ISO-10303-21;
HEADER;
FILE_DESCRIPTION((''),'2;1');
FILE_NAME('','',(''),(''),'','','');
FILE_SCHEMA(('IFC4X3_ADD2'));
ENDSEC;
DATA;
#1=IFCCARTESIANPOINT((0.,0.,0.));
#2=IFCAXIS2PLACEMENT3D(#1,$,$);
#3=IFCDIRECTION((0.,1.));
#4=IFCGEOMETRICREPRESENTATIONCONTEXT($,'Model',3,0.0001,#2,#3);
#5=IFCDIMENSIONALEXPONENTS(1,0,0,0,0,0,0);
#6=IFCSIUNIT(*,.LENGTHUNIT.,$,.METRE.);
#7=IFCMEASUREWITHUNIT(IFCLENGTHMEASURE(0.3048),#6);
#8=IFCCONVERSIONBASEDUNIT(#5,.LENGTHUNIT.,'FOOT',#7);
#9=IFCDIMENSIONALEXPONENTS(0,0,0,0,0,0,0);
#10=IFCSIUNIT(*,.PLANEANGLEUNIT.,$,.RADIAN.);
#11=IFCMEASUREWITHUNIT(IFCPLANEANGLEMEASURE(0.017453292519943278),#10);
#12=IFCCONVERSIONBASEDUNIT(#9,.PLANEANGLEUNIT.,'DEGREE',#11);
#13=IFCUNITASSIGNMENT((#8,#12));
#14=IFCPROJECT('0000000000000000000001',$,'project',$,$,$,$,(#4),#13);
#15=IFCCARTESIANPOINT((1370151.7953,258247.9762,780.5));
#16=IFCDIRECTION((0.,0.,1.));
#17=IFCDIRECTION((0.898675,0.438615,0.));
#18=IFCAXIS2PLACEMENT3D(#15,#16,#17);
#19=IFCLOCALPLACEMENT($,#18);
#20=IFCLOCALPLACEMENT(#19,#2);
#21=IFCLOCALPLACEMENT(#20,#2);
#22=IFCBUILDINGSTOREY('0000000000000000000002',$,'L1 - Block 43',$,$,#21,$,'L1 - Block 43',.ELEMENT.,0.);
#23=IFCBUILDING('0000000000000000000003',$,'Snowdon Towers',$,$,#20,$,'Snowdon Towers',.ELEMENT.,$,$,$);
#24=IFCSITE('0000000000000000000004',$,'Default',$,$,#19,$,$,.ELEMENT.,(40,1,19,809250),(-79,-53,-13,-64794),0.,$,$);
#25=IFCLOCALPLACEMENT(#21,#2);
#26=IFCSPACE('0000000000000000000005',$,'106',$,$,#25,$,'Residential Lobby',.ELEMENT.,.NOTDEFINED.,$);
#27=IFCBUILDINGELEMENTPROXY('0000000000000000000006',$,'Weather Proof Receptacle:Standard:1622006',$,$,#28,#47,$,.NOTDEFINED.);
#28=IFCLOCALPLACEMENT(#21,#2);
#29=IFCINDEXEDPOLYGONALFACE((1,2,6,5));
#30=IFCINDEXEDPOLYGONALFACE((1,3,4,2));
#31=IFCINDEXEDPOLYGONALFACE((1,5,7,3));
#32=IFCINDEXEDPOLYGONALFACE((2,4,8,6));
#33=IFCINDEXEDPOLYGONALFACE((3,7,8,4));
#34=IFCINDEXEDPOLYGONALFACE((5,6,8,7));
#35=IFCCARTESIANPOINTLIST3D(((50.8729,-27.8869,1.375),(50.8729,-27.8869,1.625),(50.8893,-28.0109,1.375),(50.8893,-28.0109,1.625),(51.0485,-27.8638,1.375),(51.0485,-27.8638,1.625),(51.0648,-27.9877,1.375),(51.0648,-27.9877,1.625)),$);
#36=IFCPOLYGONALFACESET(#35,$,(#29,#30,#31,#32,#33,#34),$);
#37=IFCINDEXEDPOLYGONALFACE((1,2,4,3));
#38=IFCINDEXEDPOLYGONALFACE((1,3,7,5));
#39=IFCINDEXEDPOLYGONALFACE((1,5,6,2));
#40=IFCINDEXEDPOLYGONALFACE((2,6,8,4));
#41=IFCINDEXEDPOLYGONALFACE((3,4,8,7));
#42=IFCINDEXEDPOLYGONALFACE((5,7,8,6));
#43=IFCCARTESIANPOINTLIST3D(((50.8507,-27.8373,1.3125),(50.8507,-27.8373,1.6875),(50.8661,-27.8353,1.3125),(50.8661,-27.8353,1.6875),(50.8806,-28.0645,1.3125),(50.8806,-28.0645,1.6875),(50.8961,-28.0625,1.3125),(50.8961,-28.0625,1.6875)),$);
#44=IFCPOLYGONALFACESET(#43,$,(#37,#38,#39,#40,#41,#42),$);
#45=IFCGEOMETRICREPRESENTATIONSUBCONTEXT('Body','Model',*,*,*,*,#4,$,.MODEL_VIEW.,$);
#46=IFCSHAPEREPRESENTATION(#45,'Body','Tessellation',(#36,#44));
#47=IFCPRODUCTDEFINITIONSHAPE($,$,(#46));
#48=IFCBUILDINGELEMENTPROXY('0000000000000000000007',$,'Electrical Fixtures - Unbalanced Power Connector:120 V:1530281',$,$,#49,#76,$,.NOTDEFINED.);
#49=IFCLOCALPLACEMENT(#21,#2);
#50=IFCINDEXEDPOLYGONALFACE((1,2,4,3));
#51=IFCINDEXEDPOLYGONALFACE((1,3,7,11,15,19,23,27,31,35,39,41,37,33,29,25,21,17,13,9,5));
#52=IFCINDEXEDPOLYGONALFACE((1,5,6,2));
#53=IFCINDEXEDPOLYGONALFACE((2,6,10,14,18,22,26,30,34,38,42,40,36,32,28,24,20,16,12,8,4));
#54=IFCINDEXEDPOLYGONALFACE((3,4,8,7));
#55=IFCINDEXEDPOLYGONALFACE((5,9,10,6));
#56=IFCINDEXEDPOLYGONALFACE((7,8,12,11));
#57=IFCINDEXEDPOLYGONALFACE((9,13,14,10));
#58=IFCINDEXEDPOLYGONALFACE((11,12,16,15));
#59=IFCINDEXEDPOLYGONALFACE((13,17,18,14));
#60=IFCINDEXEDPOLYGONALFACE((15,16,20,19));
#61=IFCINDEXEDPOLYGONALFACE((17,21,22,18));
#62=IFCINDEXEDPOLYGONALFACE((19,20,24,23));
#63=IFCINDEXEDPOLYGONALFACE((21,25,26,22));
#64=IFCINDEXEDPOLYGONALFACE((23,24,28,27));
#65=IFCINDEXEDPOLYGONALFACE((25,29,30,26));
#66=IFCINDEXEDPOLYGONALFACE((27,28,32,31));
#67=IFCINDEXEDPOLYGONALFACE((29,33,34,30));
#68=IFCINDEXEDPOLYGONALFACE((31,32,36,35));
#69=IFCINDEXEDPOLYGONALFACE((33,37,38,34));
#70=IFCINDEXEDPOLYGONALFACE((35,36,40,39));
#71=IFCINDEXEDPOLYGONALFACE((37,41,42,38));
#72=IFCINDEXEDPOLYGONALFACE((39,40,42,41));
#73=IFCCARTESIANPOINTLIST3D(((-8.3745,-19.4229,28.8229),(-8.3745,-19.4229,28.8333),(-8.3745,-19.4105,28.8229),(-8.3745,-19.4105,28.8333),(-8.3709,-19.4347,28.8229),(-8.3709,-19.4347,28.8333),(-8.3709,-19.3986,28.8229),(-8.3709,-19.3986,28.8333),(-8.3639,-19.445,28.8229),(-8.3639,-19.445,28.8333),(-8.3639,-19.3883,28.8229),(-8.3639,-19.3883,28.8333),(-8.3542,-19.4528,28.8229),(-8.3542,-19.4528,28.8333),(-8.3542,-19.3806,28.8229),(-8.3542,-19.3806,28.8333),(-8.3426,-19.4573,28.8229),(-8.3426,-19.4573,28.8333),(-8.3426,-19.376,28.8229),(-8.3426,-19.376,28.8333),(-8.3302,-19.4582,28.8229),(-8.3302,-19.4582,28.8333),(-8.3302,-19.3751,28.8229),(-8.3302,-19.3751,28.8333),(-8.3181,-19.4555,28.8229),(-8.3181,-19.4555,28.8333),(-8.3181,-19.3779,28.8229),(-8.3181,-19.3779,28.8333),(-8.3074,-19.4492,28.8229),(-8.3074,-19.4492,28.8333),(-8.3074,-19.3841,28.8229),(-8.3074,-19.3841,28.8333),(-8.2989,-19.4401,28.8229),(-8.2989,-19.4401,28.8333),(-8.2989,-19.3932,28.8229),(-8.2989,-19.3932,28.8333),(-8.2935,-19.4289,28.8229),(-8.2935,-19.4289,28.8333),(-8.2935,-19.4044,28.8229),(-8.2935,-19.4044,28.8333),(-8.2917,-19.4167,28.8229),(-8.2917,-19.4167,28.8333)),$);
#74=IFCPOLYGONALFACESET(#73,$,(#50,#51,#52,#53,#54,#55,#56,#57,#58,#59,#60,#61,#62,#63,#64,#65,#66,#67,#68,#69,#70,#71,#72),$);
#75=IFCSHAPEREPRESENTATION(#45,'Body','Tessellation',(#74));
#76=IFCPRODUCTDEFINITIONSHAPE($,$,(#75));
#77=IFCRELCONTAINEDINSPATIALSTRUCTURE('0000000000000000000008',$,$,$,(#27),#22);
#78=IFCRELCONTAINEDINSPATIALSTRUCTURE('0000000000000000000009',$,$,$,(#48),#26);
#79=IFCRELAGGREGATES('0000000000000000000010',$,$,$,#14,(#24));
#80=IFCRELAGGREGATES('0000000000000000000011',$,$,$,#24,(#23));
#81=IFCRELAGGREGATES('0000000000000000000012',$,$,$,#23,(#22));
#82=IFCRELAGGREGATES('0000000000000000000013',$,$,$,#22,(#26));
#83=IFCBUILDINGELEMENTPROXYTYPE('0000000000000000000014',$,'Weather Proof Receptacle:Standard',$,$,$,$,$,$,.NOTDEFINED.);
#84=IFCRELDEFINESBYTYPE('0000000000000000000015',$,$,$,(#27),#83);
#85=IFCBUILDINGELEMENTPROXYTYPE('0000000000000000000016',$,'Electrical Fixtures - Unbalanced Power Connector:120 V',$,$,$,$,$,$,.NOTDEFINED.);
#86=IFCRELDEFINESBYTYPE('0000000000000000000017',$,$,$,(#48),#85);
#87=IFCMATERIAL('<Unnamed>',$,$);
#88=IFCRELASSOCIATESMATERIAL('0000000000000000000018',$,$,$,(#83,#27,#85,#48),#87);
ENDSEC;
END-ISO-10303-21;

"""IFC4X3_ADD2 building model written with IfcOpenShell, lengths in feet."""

from ifc_helpers import new_model, entity, si_unit, converted_unit, direction, frame, frame_2d, origin, origin_2d_with_axis, place, context, subcontext, project, spatial, rectangle, circle, extrude, source, transform, mapped, material, type_object, type_shapes, element, save


model = new_model("IFC4X3_ADD2")

# Units and contexts
model_context = context("Model", 3, precision=0.0001, world=origin(), true_north=direction((0.0, 1.0)))
body_context = subcontext(model_context, "Body", "Model", "MODEL_VIEW")
ifc_project = project(units=[converted_unit("LENGTHUNIT", "FOOT", entity("IfcLengthMeasure", 0.3048), si_unit("LENGTHUNIT", "METRE"), dimensions=[1, 0, 0, 0, 0, 0, 0]), converted_unit("PLANEANGLEUNIT", "DEGREE", entity("IfcPlaneAngleMeasure", 0.017453292519943278), si_unit("PLANEANGLEUNIT", "RADIAN"), dimensions=[0, 0, 0, 0, 0, 0, 0])], contexts=[model_context])

# Site, building, storey
site_placement = place(None, frame((1370151.7953, 258247.9762, 780.5), z_axis=(0.0, 0.0, 1.0), x_axis=(0.898675, 0.438615, 0.0)))
site = spatial("IfcSite", under=ifc_project, at=site_placement, Name="Default", CompositionType="ELEMENT", RefLatitude=(40, 1, 19, 809250), RefLongitude=(-79, -53, -13, -64794), RefElevation=0.0)
building_placement = place(site_placement, origin())
building = spatial("IfcBuilding", under=site, at=building_placement, Name="Snowdon Towers", LongName="Snowdon Towers", CompositionType="ELEMENT")
storey_placement = place(building_placement, origin())
storey = spatial("IfcBuildingStorey", under=building, at=storey_placement, Name="L1 - Block 43", LongName="L1 - Block 43", CompositionType="ELEMENT", Elevation=0.0)

# Shared definitions
ifc_material_1 = material(Name="<Unnamed>")

# Shared definitions
space_1_placement = place(storey_placement, origin())
space_1 = spatial("IfcSpace", under=storey, at=space_1_placement, Name="106", LongName="Residential Lobby", CompositionType="ELEMENT", PredefinedType="NOTDEFINED")

# Building element proxies
building_element_proxy_type_1 = type_object("IfcBuildingElementProxyType", Name="Weather Proof Receptacle:Standard", PredefinedType="NOTDEFINED", material=ifc_material_1)
shared_shape_1 = source(origin(), body_context, "Body", "SweptSolid", [
    extrude(rectangle(XDim=0.125, YDim=0.25, at=origin_2d_with_axis()), frame((0.0, 0.0, -0.1771), z_axis=(0.0, 0.0, 1.0), x_axis=(-1.0, 0.0, 0.0)), (0.0, 0.0, 1.0), 0.1771),
    extrude(rectangle(XDim=0.2292, YDim=0.375, at=frame_2d((0.0, 0.0), x_axis=(1.0, 0.0))), frame((0.0, 0.0, 0.0), z_axis=(0.0, 0.0, 1.0), x_axis=(-1.0, 0.0, 0.0)), (0.0, 0.0, 1.0), 0.0156),
])
type_shapes(building_element_proxy_type_1, [shared_shape_1])
proxy_1_placement = place(storey_placement, frame((50.8811, -27.9489, 1.5), z_axis=(-0.991445, -0.130526, 0.0), x_axis=(0.130526, -0.991445, 0.0)))
element("IfcBuildingElementProxy", 1, at=proxy_1_placement, inside=storey, type_object=building_element_proxy_type_1, material=ifc_material_1, Name="Weather Proof Receptacle:Standard:1622006", PredefinedType="NOTDEFINED", context=body_context, shape_type="MappedRepresentation", body=[
    mapped(shared_shape_1, transform((0.0, 0.0, 0.0), scale=1.0)),
])
building_element_proxy_type_2 = type_object("IfcBuildingElementProxyType", Name="Electrical Fixtures - Unbalanced Power Connector:120 V", PredefinedType="NOTDEFINED", material=ifc_material_1)
shared_shape_2 = source(origin(), body_context, "Body", "SweptSolid", [
    extrude(circle(Radius=0.0417, at=frame_2d((0.0, 0.0), x_axis=(1.0, 0.0))), origin(), (0.0, 0.0, 1.0), 0.0104),
])
type_shapes(building_element_proxy_type_2, [shared_shape_2])
proxy_2_placement = place(space_1_placement, frame((-8.3333, -19.4167, 28.8333), z_axis=(0.0, 0.0, -1.0), x_axis=(1.0, 0.0, 0.0)))
element("IfcBuildingElementProxy", 2, at=proxy_2_placement, inside=space_1, type_object=building_element_proxy_type_2, material=ifc_material_1, Name="Electrical Fixtures - Unbalanced Power Connector:120 V:1530281", PredefinedType="NOTDEFINED", context=body_context, shape_type="MappedRepresentation", body=[
    mapped(shared_shape_2, transform((0.0, 0.0, 0.0), scale=1.0)),
])

save(model, "model.ifc")
